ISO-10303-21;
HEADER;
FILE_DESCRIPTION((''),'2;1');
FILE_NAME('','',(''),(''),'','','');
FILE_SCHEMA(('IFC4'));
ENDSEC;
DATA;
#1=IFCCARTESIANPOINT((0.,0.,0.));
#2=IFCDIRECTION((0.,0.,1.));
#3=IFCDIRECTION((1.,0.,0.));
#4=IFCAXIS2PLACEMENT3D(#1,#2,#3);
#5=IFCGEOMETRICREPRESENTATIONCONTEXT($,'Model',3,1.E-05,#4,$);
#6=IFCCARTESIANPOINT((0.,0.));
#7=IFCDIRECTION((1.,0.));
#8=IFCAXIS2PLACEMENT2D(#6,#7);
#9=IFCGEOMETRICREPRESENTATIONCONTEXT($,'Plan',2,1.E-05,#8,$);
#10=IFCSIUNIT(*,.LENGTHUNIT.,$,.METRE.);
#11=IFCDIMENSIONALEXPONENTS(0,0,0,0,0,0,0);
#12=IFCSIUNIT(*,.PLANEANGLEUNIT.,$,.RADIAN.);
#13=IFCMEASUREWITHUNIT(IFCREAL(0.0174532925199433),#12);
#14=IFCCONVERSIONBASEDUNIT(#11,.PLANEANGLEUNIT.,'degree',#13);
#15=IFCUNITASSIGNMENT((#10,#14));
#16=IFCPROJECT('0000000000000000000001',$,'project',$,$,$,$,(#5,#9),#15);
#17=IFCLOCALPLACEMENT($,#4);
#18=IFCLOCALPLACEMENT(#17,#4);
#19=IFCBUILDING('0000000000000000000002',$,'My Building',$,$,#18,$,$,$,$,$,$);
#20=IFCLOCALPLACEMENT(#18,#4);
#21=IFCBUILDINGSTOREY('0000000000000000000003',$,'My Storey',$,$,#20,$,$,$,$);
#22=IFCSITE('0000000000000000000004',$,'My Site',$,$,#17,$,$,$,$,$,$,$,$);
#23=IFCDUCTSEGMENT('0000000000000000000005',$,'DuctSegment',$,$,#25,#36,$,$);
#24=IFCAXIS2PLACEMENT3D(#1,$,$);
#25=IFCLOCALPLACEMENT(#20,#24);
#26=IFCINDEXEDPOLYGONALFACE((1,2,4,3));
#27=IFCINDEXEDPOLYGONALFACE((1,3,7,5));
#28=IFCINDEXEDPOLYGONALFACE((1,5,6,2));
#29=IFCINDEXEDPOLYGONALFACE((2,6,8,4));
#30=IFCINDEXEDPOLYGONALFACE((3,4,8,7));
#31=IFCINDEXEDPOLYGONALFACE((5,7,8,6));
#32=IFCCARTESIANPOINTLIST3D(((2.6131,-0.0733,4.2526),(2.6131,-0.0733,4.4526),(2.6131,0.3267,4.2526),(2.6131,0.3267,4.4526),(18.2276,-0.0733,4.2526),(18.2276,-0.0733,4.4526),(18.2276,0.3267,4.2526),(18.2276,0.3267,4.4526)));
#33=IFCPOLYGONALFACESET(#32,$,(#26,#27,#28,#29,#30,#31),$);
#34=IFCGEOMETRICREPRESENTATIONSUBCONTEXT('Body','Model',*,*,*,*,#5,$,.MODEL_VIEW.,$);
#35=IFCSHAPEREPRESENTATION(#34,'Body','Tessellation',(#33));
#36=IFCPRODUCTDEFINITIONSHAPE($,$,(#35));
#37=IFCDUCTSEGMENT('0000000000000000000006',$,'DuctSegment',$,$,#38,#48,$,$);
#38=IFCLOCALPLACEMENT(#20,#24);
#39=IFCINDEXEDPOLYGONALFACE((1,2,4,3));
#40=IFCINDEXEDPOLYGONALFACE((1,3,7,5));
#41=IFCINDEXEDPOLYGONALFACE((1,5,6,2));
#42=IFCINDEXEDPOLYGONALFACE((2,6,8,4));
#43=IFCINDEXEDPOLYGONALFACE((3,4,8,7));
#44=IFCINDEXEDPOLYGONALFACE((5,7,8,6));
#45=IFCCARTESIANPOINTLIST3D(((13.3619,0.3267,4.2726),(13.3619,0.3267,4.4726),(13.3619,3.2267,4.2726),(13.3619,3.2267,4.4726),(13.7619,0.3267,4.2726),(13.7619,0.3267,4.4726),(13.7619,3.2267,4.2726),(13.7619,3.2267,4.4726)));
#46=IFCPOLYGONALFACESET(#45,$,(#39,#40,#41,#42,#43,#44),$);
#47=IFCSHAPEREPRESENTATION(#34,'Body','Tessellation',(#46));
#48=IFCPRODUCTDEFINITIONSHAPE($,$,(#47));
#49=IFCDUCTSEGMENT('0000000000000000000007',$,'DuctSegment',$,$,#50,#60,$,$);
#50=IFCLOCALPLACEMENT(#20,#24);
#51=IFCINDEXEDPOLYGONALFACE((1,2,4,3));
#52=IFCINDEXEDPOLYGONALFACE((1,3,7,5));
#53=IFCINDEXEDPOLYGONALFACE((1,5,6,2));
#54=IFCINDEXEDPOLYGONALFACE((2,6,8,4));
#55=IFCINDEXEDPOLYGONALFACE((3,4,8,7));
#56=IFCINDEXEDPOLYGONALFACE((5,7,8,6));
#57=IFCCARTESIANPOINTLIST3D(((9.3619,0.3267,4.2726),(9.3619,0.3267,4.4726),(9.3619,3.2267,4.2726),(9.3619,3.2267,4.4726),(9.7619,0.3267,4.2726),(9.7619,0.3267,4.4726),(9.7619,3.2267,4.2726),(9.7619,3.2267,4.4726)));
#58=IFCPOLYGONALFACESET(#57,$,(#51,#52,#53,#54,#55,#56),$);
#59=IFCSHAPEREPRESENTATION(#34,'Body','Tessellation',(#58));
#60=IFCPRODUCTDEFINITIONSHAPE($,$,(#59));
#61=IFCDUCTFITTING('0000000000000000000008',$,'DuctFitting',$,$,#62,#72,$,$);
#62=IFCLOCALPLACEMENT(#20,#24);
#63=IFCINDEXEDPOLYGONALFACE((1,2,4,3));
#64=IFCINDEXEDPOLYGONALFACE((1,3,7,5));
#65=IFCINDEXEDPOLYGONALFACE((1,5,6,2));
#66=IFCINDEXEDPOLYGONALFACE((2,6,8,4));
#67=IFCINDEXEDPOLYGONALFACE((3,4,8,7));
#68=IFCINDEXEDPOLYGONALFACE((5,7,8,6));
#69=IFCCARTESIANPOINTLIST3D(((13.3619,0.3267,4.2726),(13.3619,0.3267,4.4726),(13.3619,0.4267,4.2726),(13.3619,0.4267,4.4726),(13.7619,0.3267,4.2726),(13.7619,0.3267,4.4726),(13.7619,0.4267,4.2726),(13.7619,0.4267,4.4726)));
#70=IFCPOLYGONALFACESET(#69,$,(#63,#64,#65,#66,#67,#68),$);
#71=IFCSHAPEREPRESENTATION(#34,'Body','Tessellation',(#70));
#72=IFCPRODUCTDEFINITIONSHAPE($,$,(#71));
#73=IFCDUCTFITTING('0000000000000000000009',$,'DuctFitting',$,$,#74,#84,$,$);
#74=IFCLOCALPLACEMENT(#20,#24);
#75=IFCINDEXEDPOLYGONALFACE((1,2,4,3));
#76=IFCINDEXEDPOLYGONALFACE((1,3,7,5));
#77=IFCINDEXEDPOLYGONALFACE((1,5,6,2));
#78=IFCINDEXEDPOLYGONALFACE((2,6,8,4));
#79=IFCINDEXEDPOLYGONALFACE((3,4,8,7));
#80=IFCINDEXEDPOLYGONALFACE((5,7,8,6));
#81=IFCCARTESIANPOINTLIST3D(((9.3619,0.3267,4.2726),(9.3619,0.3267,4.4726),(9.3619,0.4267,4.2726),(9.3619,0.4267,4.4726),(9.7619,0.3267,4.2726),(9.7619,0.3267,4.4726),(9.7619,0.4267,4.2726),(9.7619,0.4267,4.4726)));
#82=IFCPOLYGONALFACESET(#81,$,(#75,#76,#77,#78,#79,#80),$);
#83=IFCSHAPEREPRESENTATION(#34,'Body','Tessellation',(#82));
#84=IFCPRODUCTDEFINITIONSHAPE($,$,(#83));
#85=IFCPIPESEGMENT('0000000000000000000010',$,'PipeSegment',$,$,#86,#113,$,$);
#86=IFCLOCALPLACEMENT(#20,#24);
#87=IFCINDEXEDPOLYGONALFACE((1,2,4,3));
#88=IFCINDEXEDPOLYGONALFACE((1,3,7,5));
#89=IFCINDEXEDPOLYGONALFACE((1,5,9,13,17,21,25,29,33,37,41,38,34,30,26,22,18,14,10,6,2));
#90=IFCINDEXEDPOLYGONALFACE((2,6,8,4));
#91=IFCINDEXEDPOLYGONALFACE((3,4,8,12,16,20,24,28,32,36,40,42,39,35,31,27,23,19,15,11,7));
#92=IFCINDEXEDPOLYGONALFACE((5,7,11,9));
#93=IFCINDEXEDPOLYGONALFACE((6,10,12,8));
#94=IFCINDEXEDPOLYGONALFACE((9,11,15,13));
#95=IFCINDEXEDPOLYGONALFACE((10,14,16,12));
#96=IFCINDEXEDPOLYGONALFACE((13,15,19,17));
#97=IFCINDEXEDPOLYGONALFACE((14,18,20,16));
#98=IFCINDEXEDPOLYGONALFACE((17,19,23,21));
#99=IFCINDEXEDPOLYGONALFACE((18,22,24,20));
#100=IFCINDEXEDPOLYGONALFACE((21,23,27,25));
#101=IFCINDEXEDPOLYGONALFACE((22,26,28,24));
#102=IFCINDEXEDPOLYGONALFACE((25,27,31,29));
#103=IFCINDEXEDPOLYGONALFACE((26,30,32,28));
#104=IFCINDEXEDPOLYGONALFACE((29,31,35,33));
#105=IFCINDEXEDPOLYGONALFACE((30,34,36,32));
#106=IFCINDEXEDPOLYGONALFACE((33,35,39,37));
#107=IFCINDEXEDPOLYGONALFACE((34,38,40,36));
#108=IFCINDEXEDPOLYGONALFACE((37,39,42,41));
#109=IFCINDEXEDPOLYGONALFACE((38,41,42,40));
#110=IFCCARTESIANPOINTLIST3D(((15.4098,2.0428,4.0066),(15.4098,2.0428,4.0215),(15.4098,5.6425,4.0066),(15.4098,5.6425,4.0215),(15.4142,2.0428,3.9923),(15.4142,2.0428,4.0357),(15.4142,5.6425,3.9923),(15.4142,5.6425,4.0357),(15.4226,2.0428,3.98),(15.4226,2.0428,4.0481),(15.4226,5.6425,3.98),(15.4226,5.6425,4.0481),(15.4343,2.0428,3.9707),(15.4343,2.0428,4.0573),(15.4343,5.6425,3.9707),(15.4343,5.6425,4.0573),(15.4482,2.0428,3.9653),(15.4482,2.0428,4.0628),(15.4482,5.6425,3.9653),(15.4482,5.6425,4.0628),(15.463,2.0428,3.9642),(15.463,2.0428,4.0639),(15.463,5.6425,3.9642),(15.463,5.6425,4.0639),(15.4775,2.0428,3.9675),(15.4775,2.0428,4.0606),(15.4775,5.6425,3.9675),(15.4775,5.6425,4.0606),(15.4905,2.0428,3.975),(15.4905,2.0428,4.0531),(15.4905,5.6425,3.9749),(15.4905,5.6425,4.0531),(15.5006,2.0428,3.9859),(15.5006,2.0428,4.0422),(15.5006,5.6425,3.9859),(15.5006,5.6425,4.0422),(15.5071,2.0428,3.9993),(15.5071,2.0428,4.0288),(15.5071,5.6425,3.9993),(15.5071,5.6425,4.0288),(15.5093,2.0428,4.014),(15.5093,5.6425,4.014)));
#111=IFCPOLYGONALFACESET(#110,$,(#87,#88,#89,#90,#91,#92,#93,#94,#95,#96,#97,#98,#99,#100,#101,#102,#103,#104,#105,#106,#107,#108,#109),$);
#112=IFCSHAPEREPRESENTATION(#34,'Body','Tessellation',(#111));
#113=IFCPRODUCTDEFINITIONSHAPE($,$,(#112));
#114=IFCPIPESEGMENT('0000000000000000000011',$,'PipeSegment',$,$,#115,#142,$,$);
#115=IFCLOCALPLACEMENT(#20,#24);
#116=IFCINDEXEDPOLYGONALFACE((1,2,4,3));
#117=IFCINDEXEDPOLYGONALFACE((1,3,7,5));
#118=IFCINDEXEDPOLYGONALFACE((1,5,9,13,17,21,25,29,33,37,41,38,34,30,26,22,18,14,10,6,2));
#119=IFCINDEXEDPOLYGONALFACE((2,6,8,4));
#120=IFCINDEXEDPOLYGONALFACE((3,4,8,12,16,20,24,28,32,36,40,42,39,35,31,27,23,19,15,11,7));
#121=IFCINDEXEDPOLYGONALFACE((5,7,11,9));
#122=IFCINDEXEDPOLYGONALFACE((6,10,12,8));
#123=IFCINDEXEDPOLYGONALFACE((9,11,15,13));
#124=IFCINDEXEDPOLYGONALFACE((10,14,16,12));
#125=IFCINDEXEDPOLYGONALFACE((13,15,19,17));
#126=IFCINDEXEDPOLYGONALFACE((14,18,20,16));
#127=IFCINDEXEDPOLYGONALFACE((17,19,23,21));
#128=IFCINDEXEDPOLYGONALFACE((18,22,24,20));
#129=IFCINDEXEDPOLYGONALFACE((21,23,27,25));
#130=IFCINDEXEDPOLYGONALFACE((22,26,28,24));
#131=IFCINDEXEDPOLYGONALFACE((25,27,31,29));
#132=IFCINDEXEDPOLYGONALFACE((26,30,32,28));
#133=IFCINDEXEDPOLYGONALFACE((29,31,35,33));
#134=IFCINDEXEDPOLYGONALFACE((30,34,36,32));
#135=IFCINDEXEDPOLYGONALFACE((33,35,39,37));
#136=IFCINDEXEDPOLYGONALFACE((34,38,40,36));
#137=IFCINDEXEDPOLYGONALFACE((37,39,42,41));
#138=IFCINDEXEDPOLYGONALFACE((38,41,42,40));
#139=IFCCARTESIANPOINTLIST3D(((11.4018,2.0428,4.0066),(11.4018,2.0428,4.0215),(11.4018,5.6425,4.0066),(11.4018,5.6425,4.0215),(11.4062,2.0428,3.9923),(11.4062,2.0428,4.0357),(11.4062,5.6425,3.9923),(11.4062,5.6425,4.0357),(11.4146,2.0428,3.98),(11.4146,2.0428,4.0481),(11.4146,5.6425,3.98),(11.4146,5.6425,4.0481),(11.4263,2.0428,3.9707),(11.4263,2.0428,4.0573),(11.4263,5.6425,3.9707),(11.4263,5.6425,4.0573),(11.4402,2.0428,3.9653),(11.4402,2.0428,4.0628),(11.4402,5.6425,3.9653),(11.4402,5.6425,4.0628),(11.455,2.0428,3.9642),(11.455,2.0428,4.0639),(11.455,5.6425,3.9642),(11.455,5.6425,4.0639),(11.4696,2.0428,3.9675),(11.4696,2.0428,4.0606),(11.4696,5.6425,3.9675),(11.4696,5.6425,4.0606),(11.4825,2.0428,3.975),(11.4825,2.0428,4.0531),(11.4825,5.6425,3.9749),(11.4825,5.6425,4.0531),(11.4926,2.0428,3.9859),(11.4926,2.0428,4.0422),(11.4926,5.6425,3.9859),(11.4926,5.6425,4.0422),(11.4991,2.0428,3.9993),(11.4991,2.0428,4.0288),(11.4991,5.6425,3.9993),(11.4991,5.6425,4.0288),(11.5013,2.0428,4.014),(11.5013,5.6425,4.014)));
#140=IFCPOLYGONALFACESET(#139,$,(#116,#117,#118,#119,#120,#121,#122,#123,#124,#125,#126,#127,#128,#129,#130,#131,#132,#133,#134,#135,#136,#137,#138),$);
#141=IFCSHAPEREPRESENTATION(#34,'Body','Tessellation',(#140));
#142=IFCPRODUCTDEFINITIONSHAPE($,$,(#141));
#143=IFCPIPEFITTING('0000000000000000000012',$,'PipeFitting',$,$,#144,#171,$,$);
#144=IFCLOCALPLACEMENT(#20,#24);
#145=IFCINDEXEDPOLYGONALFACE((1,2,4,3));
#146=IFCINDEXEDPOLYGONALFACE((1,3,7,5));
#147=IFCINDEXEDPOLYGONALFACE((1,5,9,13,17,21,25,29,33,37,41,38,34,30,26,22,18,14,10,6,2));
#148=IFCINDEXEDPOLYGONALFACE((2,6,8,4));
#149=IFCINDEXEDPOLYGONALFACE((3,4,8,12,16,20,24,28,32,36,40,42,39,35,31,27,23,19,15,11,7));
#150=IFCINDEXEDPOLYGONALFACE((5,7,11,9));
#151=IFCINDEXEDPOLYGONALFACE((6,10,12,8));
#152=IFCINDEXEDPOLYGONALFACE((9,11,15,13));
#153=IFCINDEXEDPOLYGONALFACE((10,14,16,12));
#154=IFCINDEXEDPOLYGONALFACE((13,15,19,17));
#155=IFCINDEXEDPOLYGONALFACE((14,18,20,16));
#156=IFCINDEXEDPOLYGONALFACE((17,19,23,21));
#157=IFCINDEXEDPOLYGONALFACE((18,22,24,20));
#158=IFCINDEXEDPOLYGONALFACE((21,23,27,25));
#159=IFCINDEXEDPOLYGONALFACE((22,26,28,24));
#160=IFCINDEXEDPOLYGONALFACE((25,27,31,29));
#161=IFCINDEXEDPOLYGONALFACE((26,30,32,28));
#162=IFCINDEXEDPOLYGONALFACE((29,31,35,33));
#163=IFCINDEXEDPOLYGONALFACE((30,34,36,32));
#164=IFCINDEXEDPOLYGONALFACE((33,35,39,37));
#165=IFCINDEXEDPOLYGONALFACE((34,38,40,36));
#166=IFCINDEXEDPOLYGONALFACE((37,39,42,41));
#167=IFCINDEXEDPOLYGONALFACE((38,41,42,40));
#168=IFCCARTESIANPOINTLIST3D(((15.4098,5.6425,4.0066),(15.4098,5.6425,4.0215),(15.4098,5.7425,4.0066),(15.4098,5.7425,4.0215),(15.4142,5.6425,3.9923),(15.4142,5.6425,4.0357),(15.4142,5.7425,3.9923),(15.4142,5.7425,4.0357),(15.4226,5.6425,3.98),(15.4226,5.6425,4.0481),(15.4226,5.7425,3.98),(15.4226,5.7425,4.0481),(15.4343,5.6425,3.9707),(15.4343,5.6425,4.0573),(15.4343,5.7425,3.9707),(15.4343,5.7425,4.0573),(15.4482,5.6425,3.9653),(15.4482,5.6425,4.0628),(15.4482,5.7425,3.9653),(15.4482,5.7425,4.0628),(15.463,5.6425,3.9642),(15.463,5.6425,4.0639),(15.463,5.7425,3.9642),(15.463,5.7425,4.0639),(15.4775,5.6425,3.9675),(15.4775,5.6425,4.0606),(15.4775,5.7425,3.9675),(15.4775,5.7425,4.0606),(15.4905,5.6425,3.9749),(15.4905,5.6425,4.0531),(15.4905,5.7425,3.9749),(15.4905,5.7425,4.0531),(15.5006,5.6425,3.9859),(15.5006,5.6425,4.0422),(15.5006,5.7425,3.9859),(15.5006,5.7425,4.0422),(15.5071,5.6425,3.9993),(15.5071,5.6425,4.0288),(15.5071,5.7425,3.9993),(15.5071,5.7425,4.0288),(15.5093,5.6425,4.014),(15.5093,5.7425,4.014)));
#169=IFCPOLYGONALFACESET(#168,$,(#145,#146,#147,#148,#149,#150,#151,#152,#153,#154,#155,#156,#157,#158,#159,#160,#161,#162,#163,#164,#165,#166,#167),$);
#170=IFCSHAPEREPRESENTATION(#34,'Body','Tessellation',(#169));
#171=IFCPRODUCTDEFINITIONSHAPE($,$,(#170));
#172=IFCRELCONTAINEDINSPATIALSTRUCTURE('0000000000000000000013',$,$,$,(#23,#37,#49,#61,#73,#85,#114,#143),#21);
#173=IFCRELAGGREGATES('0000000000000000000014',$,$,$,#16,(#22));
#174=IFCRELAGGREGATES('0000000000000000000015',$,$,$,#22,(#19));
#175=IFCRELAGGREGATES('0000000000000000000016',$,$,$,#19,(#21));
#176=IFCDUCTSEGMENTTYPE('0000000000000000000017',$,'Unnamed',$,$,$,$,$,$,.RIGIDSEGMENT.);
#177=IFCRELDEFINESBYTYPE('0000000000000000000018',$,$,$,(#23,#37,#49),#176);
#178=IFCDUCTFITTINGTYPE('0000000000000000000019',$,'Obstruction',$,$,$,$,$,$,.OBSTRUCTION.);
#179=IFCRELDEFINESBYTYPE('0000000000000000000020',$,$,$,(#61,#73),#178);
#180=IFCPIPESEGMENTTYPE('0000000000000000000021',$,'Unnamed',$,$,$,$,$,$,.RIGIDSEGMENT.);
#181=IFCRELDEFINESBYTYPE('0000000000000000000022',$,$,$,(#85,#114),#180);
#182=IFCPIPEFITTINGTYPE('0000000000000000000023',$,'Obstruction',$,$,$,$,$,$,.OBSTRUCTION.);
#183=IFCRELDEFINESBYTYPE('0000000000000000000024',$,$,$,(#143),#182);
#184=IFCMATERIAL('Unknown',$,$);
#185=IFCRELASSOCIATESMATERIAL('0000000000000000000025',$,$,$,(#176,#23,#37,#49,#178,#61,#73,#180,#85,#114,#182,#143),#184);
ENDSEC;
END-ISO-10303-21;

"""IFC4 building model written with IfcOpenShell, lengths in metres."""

from ifc_helpers import new_model, entity, si_unit, converted_unit, frame, origin_with_axes, origin_2d_with_axis, place, context, subcontext, project, spatial, rectangle, circle, extrude, material, material_profile, profile_set, profile_usage, type_object, element, save


model = new_model("IFC4")

# Units and contexts
model_context = context("Model", 3, precision=1e-05, world=origin_with_axes())
plan_context = context("Plan", 2, precision=1e-05, world=origin_2d_with_axis())
body_context_1 = subcontext(model_context, "Body", "Model", "MODEL_VIEW")
ifc_project = project(units=[si_unit("LENGTHUNIT", "METRE"), converted_unit("PLANEANGLEUNIT", "degree", entity("IfcReal", 0.0174532925199433), si_unit("PLANEANGLEUNIT", "RADIAN"), dimensions=[0, 0, 0, 0, 0, 0, 0])], contexts=[model_context, plan_context])

# Site, building, storey
site_placement = place(None, origin_with_axes())
site = spatial("IfcSite", under=ifc_project, at=site_placement, Name="My Site")
building_placement = place(site_placement, origin_with_axes())
building = spatial("IfcBuilding", under=site, at=building_placement, Name="My Building")
storey_placement = place(building_placement, origin_with_axes())
storey = spatial("IfcBuildingStorey", under=building, at=storey_placement, Name="My Storey")

# Shared definitions
ifc_material = material(Name="Unknown")

# Duct segments
ifc_material_profile_1 = material_profile(ifc_material, rectangle(XDim=0.4, YDim=0.2))
ifc_profile_set_1 = profile_set([ifc_material_profile_1])
ifc_profile_usage_1 = profile_usage(ifc_profile_set_1, cardinal=5)
duct_segment_type = type_object("IfcDuctSegmentType", Name="Unnamed", PredefinedType="RIGIDSEGMENT", material=ifc_profile_set_1)
duct_segment_1_placement = place(storey_placement, frame((18.2276, 0.1267, 4.3526), z_axis=(-1.0, 0.0, 0.0), x_axis=(0.0, -1.0, 0.0)))
element("IfcDuctSegment", 1, at=duct_segment_1_placement, inside=storey, type_object=duct_segment_type, material=ifc_profile_usage_1, Name="DuctSegment", context=body_context_1, shape_type="SweptSolid", body=[
    extrude(rectangle(XDim=0.4, YDim=0.2), origin_with_axes(), (0.0, 0.0, 1.0), 15.6145),
])
ifc_profile_usage_2 = profile_usage(ifc_profile_set_1, cardinal=5)
duct_segment_2_placement = place(storey_placement, frame((13.5619, 0.3267, 4.3726), z_axis=(0.0, 1.0, 0.0), x_axis=(-1.0, 0.0, 0.0)))
element("IfcDuctSegment", 2, at=duct_segment_2_placement, inside=storey, type_object=duct_segment_type, material=ifc_profile_usage_2, Name="DuctSegment", context=body_context_1, shape_type="SweptSolid", body=[
    extrude(rectangle(XDim=0.4, YDim=0.2), origin_with_axes(), (0.0, 0.0, 1.0), 2.9),
])
ifc_profile_usage_3 = profile_usage(ifc_profile_set_1, cardinal=5)
duct_segment_3_placement = place(storey_placement, frame((9.5619, 0.3267, 4.3726), z_axis=(0.0, 1.0, 0.0), x_axis=(-1.0, 0.0, 0.0)))
element("IfcDuctSegment", 3, at=duct_segment_3_placement, inside=storey, type_object=duct_segment_type, material=ifc_profile_usage_3, Name="DuctSegment", context=body_context_1, shape_type="SweptSolid", body=[
    extrude(rectangle(XDim=0.4, YDim=0.2), origin_with_axes(), (0.0, 0.0, 1.0), 2.9),
])

# Duct fittings
ifc_material_profile_2 = material_profile(ifc_material, rectangle(XDim=0.4, YDim=0.2))
ifc_profile_set_2 = profile_set([ifc_material_profile_2])
ifc_profile_usage_4 = profile_usage(ifc_profile_set_2, cardinal=5)
duct_fitting_type = type_object("IfcDuctFittingType", Name="Obstruction", PredefinedType="OBSTRUCTION", material=ifc_profile_set_2)
duct_fitting_1_placement = place(storey_placement, frame((13.5619, 0.3267, 4.3726), z_axis=(0.0, 1.0, 0.0), x_axis=(-1.0, 0.0, 0.0)))
element("IfcDuctFitting", 4, at=duct_fitting_1_placement, inside=storey, type_object=duct_fitting_type, material=ifc_profile_usage_4, Name="DuctFitting", context=body_context_1, shape_type="SweptSolid", body=[
    extrude(rectangle(XDim=0.4, YDim=0.2), origin_with_axes(), (0.0, 0.0, 1.0), 0.1),
])
ifc_profile_usage_5 = profile_usage(ifc_profile_set_2, cardinal=5)
duct_fitting_2_placement = place(storey_placement, frame((9.5619, 0.3267, 4.3726), z_axis=(0.0, 1.0, 0.0), x_axis=(-1.0, 0.0, 0.0)))
element("IfcDuctFitting", 5, at=duct_fitting_2_placement, inside=storey, type_object=duct_fitting_type, material=ifc_profile_usage_5, Name="DuctFitting", context=body_context_1, shape_type="SweptSolid", body=[
    extrude(rectangle(XDim=0.4, YDim=0.2), origin_with_axes(), (0.0, 0.0, 1.0), 0.1),
])

# Pipe segments
ifc_material_profile_3 = material_profile(ifc_material, circle(Radius=0.05))
ifc_profile_set_3 = profile_set([ifc_material_profile_3])
ifc_profile_usage_6 = profile_usage(ifc_profile_set_3, cardinal=5)
pipe_segment_type = type_object("IfcPipeSegmentType", Name="Unnamed", PredefinedType="RIGIDSEGMENT", material=ifc_profile_set_3)
pipe_segment_1_placement = place(storey_placement, frame((15.4593, 5.6425, 4.014), z_axis=(0.0, -1.0, 0.0), x_axis=(1.0, 0.0, 0.0)))
element("IfcPipeSegment", 6, at=pipe_segment_1_placement, inside=storey, type_object=pipe_segment_type, material=ifc_profile_usage_6, Name="PipeSegment", context=body_context_1, shape_type="SweptSolid", body=[
    extrude(circle(Radius=0.05), origin_with_axes(), (0.0, 0.0, 1.0), 3.5996),
])
ifc_profile_usage_7 = profile_usage(ifc_profile_set_3, cardinal=5)
pipe_segment_2_placement = place(storey_placement, frame((11.4513, 5.6425, 4.014), z_axis=(0.0, -1.0, 0.0), x_axis=(1.0, 0.0, 0.0)))
element("IfcPipeSegment", 7, at=pipe_segment_2_placement, inside=storey, type_object=pipe_segment_type, material=ifc_profile_usage_7, Name="PipeSegment", context=body_context_1, shape_type="SweptSolid", body=[
    extrude(circle(Radius=0.05), origin_with_axes(), (0.0, 0.0, 1.0), 3.5996),
])

# Pipe fitting
ifc_material_profile_4 = material_profile(ifc_material, circle(Radius=0.05))
ifc_profile_set_4 = profile_set([ifc_material_profile_4])
ifc_profile_usage_8 = profile_usage(ifc_profile_set_4, cardinal=5)
pipe_fitting_type_1 = type_object("IfcPipeFittingType", Name="Obstruction", PredefinedType="OBSTRUCTION", material=ifc_profile_set_4)
pipe_fitting_1_placement = place(storey_placement, frame((15.4593, 5.7425, 4.014), z_axis=(0.0, -1.0, 0.0), x_axis=(1.0, 0.0, 0.0)))
element("IfcPipeFitting", 8, at=pipe_fitting_1_placement, inside=storey, type_object=pipe_fitting_type_1, material=ifc_profile_usage_8, Name="PipeFitting", context=body_context_1, shape_type="SweptSolid", body=[
    extrude(circle(Radius=0.05), origin_with_axes(), (0.0, 0.0, 1.0), 0.1),
])

save(model, "model.ifc")
